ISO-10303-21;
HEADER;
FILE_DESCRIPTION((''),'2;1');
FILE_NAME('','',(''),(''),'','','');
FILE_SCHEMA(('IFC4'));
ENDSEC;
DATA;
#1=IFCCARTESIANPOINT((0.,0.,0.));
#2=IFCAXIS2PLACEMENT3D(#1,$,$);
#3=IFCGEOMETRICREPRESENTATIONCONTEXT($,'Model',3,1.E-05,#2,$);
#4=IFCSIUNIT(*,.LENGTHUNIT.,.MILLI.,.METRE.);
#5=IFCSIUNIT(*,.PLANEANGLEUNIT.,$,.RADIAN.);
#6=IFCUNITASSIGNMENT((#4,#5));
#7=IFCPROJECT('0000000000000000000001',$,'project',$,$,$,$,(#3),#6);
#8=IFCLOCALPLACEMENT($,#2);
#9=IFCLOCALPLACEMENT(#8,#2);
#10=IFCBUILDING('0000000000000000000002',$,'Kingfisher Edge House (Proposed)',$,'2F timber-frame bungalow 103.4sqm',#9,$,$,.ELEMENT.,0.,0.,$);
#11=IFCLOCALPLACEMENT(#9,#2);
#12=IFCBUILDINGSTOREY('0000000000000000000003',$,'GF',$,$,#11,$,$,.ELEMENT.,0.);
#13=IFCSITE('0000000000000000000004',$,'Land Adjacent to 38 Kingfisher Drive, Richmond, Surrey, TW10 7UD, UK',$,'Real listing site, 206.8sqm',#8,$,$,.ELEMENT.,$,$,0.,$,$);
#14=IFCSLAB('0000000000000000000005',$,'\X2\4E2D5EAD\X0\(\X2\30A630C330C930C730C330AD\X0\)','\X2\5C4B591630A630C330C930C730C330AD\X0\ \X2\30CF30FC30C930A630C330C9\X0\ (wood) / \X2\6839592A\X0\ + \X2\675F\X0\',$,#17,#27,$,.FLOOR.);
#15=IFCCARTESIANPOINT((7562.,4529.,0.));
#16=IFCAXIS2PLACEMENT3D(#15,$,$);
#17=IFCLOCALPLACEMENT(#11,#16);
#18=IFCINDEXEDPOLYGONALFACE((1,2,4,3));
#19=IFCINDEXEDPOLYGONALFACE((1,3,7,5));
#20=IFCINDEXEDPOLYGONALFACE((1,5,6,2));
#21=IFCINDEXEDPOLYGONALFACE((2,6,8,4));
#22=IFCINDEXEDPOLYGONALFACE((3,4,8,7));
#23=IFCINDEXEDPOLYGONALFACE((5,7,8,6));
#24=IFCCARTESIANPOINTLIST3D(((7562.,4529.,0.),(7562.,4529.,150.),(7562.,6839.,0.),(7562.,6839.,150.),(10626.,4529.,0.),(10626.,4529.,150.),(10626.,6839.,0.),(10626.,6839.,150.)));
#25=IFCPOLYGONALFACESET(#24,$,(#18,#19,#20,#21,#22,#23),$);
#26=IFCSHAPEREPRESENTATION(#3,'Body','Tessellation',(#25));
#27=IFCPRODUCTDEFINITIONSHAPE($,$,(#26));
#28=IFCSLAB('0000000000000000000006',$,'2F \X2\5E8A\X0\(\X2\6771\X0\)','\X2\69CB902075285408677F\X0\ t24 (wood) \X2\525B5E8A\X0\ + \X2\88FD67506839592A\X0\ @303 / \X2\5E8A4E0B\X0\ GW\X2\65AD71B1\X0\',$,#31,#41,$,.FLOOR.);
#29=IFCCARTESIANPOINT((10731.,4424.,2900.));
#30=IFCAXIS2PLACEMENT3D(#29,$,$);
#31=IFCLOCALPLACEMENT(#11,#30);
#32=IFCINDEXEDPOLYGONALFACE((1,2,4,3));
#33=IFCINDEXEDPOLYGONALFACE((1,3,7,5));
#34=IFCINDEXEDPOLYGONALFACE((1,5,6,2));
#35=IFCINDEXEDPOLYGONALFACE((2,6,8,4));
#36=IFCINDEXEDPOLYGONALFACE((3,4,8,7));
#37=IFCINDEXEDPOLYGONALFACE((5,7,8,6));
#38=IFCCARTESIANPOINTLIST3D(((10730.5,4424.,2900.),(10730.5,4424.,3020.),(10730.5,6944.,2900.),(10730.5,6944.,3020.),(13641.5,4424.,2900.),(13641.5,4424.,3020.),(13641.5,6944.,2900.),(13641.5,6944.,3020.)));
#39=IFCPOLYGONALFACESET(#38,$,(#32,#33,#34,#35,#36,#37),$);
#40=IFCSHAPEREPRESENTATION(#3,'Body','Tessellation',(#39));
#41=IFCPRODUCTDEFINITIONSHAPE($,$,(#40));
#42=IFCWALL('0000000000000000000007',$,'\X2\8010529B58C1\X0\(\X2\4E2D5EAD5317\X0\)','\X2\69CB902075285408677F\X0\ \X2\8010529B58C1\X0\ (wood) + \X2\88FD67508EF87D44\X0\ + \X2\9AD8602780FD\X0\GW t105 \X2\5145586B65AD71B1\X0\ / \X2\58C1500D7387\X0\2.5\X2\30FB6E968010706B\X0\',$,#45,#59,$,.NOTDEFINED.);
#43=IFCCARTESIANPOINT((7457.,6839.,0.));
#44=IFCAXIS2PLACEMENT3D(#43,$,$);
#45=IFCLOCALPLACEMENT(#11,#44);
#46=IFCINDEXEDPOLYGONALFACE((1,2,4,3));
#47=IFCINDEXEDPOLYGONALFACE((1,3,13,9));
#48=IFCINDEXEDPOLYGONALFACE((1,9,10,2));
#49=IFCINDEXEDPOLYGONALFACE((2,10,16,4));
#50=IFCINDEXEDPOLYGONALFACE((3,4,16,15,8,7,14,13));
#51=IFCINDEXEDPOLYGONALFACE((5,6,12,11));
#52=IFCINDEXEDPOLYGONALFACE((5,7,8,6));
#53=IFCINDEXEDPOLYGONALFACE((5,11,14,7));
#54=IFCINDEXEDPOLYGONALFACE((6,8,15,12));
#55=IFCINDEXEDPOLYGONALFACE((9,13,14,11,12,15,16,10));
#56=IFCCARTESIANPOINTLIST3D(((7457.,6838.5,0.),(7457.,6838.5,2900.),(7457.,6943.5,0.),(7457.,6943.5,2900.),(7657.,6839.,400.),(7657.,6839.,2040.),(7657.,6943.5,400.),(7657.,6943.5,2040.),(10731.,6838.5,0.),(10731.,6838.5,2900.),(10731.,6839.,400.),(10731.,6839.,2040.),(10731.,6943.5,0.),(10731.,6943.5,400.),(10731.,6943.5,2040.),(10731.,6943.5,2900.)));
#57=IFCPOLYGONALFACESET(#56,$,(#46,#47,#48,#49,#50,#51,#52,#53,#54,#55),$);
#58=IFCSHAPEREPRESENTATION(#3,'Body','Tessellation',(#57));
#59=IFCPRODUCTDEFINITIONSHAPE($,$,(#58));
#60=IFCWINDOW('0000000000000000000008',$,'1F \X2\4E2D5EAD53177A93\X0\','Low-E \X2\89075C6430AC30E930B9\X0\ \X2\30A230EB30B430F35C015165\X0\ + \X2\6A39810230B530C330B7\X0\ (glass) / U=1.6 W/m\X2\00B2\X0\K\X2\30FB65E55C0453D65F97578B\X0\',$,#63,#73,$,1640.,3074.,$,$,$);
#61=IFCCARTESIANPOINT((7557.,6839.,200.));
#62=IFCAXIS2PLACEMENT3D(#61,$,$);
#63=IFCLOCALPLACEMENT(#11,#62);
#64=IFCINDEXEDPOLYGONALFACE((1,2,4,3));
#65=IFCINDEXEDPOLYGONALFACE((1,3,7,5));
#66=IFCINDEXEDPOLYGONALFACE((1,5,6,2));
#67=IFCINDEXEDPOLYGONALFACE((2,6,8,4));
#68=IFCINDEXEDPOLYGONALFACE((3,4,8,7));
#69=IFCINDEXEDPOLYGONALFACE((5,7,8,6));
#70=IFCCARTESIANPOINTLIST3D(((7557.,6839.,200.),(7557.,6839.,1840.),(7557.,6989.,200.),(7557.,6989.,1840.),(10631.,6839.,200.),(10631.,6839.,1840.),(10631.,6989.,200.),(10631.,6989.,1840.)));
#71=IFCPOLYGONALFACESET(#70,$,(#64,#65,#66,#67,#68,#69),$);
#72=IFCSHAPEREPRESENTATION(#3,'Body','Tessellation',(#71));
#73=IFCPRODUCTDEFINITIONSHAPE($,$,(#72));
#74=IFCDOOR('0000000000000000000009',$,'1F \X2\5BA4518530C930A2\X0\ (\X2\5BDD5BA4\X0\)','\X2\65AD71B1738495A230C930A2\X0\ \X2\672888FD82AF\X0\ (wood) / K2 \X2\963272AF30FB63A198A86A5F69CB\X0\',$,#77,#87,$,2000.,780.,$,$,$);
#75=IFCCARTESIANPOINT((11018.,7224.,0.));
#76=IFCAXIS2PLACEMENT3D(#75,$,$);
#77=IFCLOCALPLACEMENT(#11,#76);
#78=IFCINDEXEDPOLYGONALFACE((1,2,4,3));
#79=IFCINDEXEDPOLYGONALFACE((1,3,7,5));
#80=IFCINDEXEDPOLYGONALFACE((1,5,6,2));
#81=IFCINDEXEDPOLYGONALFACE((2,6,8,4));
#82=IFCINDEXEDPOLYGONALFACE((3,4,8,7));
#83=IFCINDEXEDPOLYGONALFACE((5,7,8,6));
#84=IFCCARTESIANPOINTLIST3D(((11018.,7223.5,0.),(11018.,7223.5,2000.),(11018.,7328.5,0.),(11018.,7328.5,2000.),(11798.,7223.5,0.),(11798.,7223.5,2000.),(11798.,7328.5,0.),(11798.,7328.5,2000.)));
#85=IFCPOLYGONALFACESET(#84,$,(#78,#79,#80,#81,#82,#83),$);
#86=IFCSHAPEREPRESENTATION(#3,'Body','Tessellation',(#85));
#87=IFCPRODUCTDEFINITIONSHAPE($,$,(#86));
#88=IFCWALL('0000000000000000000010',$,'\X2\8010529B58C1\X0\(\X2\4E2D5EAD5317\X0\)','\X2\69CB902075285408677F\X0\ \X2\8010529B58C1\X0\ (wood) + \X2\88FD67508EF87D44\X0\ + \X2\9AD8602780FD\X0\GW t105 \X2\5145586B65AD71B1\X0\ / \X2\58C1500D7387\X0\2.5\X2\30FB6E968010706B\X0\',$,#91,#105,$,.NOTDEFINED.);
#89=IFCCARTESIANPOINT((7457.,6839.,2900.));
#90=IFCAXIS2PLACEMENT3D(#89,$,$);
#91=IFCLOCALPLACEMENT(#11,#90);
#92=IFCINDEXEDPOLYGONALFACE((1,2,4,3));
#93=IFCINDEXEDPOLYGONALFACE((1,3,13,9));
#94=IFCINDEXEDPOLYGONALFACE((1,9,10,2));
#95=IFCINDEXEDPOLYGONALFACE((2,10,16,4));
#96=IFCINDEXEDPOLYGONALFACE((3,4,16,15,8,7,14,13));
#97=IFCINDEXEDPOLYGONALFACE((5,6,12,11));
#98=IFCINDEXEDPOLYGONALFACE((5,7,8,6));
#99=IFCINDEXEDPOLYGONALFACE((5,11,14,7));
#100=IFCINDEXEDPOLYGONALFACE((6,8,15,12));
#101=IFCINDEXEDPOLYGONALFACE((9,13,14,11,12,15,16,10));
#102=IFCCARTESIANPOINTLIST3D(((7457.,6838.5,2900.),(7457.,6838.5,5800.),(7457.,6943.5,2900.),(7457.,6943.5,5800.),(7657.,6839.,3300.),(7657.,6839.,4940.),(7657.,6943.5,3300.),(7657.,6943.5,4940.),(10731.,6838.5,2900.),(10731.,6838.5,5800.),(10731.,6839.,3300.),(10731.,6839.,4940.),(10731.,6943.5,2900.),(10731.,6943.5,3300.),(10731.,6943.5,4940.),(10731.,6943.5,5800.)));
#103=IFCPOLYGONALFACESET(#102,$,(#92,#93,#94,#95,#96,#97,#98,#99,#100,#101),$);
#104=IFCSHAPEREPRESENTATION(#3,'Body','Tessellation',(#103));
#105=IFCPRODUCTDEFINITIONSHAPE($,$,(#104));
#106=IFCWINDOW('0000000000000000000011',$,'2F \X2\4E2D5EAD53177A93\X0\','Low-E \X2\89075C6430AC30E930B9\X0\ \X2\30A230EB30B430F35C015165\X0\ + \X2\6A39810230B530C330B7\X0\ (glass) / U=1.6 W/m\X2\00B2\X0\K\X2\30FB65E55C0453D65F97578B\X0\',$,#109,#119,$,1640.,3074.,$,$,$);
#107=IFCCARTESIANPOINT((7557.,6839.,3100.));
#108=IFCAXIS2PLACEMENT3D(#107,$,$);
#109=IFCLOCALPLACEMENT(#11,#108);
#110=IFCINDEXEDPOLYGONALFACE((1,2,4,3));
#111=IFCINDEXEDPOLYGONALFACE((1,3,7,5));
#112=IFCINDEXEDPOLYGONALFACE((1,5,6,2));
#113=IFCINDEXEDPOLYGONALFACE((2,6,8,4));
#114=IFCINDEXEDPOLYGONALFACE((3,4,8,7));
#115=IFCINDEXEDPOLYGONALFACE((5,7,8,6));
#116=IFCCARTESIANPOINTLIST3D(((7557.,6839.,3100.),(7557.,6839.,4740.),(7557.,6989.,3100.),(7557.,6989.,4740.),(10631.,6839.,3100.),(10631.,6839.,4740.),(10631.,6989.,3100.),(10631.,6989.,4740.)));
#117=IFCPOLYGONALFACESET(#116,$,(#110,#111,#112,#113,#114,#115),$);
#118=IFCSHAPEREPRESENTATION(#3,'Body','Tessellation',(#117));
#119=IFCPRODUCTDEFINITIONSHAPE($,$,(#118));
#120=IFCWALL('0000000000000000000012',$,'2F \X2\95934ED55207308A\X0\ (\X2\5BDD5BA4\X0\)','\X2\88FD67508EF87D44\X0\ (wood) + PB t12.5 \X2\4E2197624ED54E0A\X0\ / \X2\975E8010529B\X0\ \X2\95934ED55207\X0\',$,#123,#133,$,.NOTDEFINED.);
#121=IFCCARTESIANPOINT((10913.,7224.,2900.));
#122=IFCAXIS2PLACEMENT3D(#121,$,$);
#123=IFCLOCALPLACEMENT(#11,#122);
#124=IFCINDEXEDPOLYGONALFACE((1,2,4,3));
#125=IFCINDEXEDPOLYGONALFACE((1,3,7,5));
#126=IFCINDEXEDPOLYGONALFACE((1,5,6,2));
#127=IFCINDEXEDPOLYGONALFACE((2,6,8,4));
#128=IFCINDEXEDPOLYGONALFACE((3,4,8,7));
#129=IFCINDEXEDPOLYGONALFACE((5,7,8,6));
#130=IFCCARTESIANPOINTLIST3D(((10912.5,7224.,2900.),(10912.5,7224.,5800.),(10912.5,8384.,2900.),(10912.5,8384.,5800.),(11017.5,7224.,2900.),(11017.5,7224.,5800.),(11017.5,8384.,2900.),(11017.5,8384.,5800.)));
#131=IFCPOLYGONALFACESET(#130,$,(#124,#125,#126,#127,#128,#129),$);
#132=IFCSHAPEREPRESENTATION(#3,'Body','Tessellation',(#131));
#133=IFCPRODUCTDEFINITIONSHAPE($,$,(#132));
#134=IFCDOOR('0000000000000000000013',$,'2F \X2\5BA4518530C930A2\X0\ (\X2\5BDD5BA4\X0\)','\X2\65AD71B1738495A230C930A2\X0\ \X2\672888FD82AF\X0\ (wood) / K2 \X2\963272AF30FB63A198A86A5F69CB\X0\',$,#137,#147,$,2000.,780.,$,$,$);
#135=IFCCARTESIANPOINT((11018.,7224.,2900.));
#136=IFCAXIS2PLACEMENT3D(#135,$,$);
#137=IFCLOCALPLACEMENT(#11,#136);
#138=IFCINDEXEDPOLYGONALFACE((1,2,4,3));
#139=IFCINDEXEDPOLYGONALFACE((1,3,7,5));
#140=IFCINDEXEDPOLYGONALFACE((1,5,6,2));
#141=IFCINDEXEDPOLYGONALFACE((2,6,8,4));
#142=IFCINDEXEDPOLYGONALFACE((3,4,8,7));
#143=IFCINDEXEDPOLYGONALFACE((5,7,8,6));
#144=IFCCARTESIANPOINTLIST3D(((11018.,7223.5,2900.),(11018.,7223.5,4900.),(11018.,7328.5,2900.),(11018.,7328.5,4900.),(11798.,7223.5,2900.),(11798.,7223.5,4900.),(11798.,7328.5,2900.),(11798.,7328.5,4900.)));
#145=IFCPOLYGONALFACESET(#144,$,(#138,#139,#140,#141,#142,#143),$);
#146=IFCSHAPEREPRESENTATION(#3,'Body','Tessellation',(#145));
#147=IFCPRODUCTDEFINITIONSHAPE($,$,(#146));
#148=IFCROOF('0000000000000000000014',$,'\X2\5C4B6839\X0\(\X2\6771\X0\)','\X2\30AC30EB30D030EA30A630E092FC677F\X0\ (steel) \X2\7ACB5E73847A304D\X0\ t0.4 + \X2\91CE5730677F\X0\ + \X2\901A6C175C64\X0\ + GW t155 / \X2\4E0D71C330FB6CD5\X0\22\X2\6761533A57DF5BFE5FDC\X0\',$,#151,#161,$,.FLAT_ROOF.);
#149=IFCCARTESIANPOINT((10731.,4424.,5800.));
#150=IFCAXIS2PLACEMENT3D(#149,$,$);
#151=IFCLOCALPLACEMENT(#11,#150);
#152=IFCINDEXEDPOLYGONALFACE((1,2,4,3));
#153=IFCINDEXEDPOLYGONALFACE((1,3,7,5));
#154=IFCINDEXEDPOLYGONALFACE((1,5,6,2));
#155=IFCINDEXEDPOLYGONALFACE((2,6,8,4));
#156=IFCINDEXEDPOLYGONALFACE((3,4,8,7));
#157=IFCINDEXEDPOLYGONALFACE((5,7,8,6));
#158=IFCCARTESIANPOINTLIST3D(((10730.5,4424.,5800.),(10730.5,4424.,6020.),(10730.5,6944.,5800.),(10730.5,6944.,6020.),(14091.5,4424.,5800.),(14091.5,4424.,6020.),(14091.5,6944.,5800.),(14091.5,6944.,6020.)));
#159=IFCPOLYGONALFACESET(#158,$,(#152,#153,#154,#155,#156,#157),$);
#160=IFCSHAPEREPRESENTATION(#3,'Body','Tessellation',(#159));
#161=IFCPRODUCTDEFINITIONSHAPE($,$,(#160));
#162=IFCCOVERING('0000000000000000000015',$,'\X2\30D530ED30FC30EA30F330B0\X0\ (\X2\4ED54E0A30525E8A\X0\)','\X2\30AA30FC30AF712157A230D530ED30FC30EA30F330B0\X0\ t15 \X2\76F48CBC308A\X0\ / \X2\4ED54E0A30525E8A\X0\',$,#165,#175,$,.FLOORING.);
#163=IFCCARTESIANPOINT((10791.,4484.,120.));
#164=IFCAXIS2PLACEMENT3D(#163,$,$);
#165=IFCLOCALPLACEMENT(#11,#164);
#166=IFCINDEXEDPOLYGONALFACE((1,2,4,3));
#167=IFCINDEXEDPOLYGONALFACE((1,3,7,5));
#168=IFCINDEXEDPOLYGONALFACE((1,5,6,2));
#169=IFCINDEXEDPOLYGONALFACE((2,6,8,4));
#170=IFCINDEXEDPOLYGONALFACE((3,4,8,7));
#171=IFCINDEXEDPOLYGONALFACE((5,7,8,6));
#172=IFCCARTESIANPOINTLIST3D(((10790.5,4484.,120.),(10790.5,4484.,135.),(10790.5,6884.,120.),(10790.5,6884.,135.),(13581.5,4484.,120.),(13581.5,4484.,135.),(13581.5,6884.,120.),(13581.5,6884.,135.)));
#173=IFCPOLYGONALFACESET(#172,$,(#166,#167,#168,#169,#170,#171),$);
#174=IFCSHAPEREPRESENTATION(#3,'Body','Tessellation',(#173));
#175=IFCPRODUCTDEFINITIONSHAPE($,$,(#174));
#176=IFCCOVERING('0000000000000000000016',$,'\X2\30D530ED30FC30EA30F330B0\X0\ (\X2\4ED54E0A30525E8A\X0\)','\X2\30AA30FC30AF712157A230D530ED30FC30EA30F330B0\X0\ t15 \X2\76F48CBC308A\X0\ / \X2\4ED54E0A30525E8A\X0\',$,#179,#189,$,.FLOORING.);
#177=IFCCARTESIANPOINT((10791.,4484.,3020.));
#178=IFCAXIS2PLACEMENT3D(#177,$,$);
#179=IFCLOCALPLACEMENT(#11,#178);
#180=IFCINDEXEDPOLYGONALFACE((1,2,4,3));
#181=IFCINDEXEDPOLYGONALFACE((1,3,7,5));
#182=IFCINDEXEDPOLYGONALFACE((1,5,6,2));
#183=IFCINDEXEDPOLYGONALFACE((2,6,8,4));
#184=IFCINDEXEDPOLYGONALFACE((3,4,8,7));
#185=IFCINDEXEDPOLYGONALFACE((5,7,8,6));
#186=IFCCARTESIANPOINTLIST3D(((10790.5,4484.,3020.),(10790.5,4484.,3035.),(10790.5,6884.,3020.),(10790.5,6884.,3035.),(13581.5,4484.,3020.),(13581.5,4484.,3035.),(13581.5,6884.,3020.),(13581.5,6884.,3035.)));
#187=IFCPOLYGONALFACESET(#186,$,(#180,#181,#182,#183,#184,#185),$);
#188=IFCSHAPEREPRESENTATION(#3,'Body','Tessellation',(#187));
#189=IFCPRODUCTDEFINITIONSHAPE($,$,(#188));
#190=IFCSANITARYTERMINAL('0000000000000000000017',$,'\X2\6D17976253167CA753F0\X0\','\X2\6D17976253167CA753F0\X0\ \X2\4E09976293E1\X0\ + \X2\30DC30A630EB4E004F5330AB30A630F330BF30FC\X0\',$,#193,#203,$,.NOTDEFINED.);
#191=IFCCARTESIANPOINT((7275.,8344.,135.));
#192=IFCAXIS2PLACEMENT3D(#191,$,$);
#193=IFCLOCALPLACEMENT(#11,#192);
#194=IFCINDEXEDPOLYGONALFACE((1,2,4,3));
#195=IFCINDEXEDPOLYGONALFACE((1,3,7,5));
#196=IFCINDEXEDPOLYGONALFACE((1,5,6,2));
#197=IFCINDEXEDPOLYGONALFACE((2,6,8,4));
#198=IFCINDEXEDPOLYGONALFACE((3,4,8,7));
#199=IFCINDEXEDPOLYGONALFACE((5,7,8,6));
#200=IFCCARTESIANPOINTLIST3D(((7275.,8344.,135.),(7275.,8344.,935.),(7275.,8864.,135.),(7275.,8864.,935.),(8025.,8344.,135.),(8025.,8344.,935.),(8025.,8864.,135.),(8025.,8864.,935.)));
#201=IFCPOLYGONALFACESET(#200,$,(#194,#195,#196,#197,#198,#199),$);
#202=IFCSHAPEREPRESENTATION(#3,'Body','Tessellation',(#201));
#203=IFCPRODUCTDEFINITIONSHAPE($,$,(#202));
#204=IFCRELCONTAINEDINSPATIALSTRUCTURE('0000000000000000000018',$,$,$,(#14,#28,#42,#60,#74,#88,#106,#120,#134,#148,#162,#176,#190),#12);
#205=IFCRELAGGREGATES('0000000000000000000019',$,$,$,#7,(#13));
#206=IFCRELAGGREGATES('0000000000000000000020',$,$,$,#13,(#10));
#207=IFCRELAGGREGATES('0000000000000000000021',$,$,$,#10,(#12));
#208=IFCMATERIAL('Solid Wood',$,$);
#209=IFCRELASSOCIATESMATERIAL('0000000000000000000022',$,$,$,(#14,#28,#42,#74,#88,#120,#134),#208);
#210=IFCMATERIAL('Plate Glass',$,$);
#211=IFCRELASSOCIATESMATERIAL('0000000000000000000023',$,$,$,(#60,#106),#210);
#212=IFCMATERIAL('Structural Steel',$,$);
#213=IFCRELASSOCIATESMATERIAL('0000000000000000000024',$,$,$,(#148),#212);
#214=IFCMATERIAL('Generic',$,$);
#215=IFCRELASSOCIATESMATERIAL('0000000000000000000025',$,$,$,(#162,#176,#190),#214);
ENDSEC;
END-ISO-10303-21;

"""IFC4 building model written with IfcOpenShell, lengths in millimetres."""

from ifc_helpers import new_model, si_unit, frame, frame_2d, origin, place, context, project, spatial, rectangle, extrude, material, element, fill, save


model = new_model("IFC4")

# Units and contexts
model_context = context("Model", 3, precision=1e-05, world=origin())
ifc_project = project(units=[si_unit("LENGTHUNIT", "METRE", prefix="MILLI"), si_unit("PLANEANGLEUNIT", "RADIAN")], contexts=[model_context])

# Site, building, storey
site_placement = place(None, origin())
site = spatial("IfcSite", under=ifc_project, at=site_placement, Name="Land Adjacent to 38 Kingfisher Drive, Richmond, Surrey, TW10 7UD, UK", ObjectType="Real listing site, 206.8sqm", CompositionType="ELEMENT", RefElevation=0.0)
building_placement = place(site_placement, origin())
building = spatial("IfcBuilding", under=site, at=building_placement, Name="Kingfisher Edge House (Proposed)", ObjectType="2F timber-frame bungalow 103.4sqm", CompositionType="ELEMENT", ElevationOfRefHeight=0.0, ElevationOfTerrain=0.0)
storey_placement = place(building_placement, origin())
storey = spatial("IfcBuildingStorey", under=building, at=storey_placement, Name="GF", CompositionType="ELEMENT", Elevation=0.0)

# Slabs
ifc_material_1 = material(Name="Solid Wood")
slab_1_placement = place(storey_placement, frame((7562.0, 4529.0, 0.0)))
element("IfcSlab", 1, at=slab_1_placement, inside=storey, material=ifc_material_1, Name="中庭(ウッドデッキ)", Description="屋外ウッドデッキ ハードウッド (wood) / 根太 + 束", PredefinedType="FLOOR", context=model_context, shape_type="SweptSolid", body=[
    extrude(rectangle(XDim=3064.0, YDim=2310.0, at=frame_2d((1532.0, 1155.0))), frame((7562.0, 4529.0, 0.0)), (0.0, 0.0, 1.0), 150.0),
])
slab_2_placement = place(storey_placement, frame((10731.0, 4424.0, 2900.0)))
element("IfcSlab", 2, at=slab_2_placement, inside=storey, material=ifc_material_1, Name="2F 床(東)", Description="構造用合板 t24 (wood) 剛床 + 製材根太 @303 / 床下 GW断熱", PredefinedType="FLOOR", context=model_context, shape_type="SweptSolid", body=[
    extrude(rectangle(XDim=2911.0, YDim=2520.0, at=frame_2d((1455.0, 1260.0))), frame((10731.0, 4424.0, 2900.0)), (0.0, 0.0, 1.0), 120.0),
])

# Wall, opening, window
wall_1_placement = place(storey_placement, frame((7457.0, 6839.0, 0.0)))
wall_1 = element("IfcWall", 3, at=wall_1_placement, inside=storey, material=ifc_material_1, Name="耐力壁(中庭北)", Description="構造用合板 耐力壁 (wood) + 製材軸組 + 高性能GW t105 充填断熱 / 壁倍率2.5・準耐火", PredefinedType="NOTDEFINED", context=model_context, shape_type="SweptSolid", body=[
    extrude(rectangle(XDim=3274.0, YDim=105.0, at=frame_2d((1637.0, 52.0))), frame((7457.0, 6839.0, 0.0)), (0.0, 0.0, 1.0), 2900.0),
])
opening_1_placement = place(storey_placement, frame((7557.0, 6839.0, 200.0)))
opening_1 = element("IfcOpeningElement", 4, at=opening_1_placement, cuts=wall_1, PredefinedType="NOTDEFINED", context=model_context, shape_type="SweptSolid", body=[
    extrude(rectangle(XDim=3074.0, YDim=150.0, at=frame_2d((1537.0, 75.0))), frame((7557.0, 6839.0, 200.0)), (0.0, 0.0, 1.0), 1640.0),
])
ifc_material_2 = material(Name="Plate Glass")
window_1_placement = place(storey_placement, frame((7557.0, 6839.0, 200.0)))
window_1 = element("IfcWindow", 5, at=window_1_placement, inside=storey, material=ifc_material_2, Name="1F 中庭北窓", Description="Low-E 複層ガラス アルゴン封入 + 樹脂サッシ (glass) / U=1.6 W/m²K・日射取得型", OverallHeight=1640.0, OverallWidth=3074.0, context=model_context, shape_type="SweptSolid", body=[
    extrude(rectangle(XDim=3074.0, YDim=150.0, at=frame_2d((1537.0, 75.0))), frame((7557.0, 6839.0, 200.0)), (0.0, 0.0, 1.0), 1640.0),
])
fill(opening_1, window_1)

# Door
door_1_placement = place(storey_placement, frame((11018.0, 7224.0, 0.0)))
element("IfcDoor", 6, at=door_1_placement, inside=storey, material=ifc_material_1, Name="1F 室内ドア (寝室)", Description="断熱玄関ドア 木製芯 (wood) / K2 防犯・採風機構", OverallHeight=2000.0, OverallWidth=780.0, context=model_context, shape_type="SweptSolid", body=[
    extrude(rectangle(XDim=780.0, YDim=105.0, at=frame_2d((390.0, 52.0))), frame((11018.0, 7224.0, 0.0)), (0.0, 0.0, 1.0), 2000.0),
])

# Wall, opening, window
wall_2_placement = place(storey_placement, frame((7457.0, 6839.0, 2900.0)))
wall_2 = element("IfcWall", 7, at=wall_2_placement, inside=storey, material=ifc_material_1, Name="耐力壁(中庭北)", Description="構造用合板 耐力壁 (wood) + 製材軸組 + 高性能GW t105 充填断熱 / 壁倍率2.5・準耐火", PredefinedType="NOTDEFINED", context=model_context, shape_type="SweptSolid", body=[
    extrude(rectangle(XDim=3274.0, YDim=105.0, at=frame_2d((1637.0, 52.0))), frame((7457.0, 6839.0, 2900.0)), (0.0, 0.0, 1.0), 2900.0),
])
opening_2_placement = place(storey_placement, frame((7557.0, 6839.0, 3100.0)))
opening_2 = element("IfcOpeningElement", 8, at=opening_2_placement, cuts=wall_2, PredefinedType="NOTDEFINED", context=model_context, shape_type="SweptSolid", body=[
    extrude(rectangle(XDim=3074.0, YDim=150.0, at=frame_2d((1537.0, 75.0))), frame((7557.0, 6839.0, 3100.0)), (0.0, 0.0, 1.0), 1640.0),
])
window_2_placement = place(storey_placement, frame((7557.0, 6839.0, 3100.0)))
window_2 = element("IfcWindow", 9, at=window_2_placement, inside=storey, material=ifc_material_2, Name="2F 中庭北窓", Description="Low-E 複層ガラス アルゴン封入 + 樹脂サッシ (glass) / U=1.6 W/m²K・日射取得型", OverallHeight=1640.0, OverallWidth=3074.0, context=model_context, shape_type="SweptSolid", body=[
    extrude(rectangle(XDim=3074.0, YDim=150.0, at=frame_2d((1537.0, 75.0))), frame((7557.0, 6839.0, 3100.0)), (0.0, 0.0, 1.0), 1640.0),
])
fill(opening_2, window_2)

# Wall
wall_3_placement = place(storey_placement, frame((10913.0, 7224.0, 2900.0)))
element("IfcWall", 10, at=wall_3_placement, inside=storey, material=ifc_material_1, Name="2F 間仕切り (寝室)", Description="製材軸組 (wood) + PB t12.5 両面仕上 / 非耐力 間仕切", PredefinedType="NOTDEFINED", context=model_context, shape_type="SweptSolid", body=[
    extrude(rectangle(XDim=105.0, YDim=1160.0, at=frame_2d((52.0, 580.0))), frame((10913.0, 7224.0, 2900.0)), (0.0, 0.0, 1.0), 2900.0),
])

# Door
door_2_placement = place(storey_placement, frame((11018.0, 7224.0, 2900.0)))
element("IfcDoor", 11, at=door_2_placement, inside=storey, material=ifc_material_1, Name="2F 室内ドア (寝室)", Description="断熱玄関ドア 木製芯 (wood) / K2 防犯・採風機構", OverallHeight=2000.0, OverallWidth=780.0, context=model_context, shape_type="SweptSolid", body=[
    extrude(rectangle(XDim=780.0, YDim=105.0, at=frame_2d((390.0, 52.0))), frame((11018.0, 7224.0, 2900.0)), (0.0, 0.0, 1.0), 2000.0),
])

# Roof
ifc_material_3 = material(Name="Structural Steel")
for number, where, name in (
    (12, (10731.0, 4424.0, 5800.0), "屋根(東)"),
):
    element("IfcRoof", number, at=place(storey_placement, frame(where)), inside=storey, material=ifc_material_3, Name=name, Description="ガルバリウム鋼板 (steel) 立平葺き t0.4 + 野地板 + 通気層 + GW t155 / 不燃・法22条区域対応", PredefinedType="FLAT_ROOF", context=model_context, shape_type="SweptSolid", body=[
        extrude(rectangle(XDim=3361.0, YDim=2520.0, at=frame_2d((1680.0, 1260.0))), frame((10731.0, 4424.0, 5800.0)), (0.0, 0.0, 1.0), 220.0),
    ])

# Coverings
ifc_material_4 = material(Name="Generic")
covering_1_placement = place(storey_placement, frame((10791.0, 4484.0, 120.0)))
element("IfcCovering", 13, at=covering_1_placement, inside=storey, material=ifc_material_4, Name="フローリング (仕上げ床)", Description="オーク無垢フローリング t15 直貼り / 仕上げ床", PredefinedType="FLOORING", context=model_context, shape_type="SweptSolid", body=[
    extrude(rectangle(XDim=2791.0, YDim=2400.0, at=frame_2d((1395.0, 1200.0))), frame((10791.0, 4484.0, 120.0)), (0.0, 0.0, 1.0), 15.0),
])
covering_2_placement = place(storey_placement, frame((10791.0, 4484.0, 3020.0)))
element("IfcCovering", 14, at=covering_2_placement, inside=storey, material=ifc_material_4, Name="フローリング (仕上げ床)", Description="オーク無垢フローリング t15 直貼り / 仕上げ床", PredefinedType="FLOORING", context=model_context, shape_type="SweptSolid", body=[
    extrude(rectangle(XDim=2791.0, YDim=2400.0, at=frame_2d((1395.0, 1200.0))), frame((10791.0, 4484.0, 3020.0)), (0.0, 0.0, 1.0), 15.0),
])

# Sanitary terminal
sanitary_terminal_1_placement = place(storey_placement, frame((7275.0, 8344.0, 135.0)))
element("IfcSanitaryTerminal", 15, at=sanitary_terminal_1_placement, inside=storey, material=ifc_material_4, Name="洗面化粧台", Description="洗面化粧台 三面鏡 + ボウル一体カウンター", PredefinedType="NOTDEFINED", context=model_context, shape_type="SweptSolid", body=[
    extrude(rectangle(XDim=750.0, YDim=520.0, at=frame_2d((375.0, 260.0))), frame((7275.0, 8344.0, 135.0)), (0.0, 0.0, 1.0), 800.0),
])

save(model, "model.ifc")
